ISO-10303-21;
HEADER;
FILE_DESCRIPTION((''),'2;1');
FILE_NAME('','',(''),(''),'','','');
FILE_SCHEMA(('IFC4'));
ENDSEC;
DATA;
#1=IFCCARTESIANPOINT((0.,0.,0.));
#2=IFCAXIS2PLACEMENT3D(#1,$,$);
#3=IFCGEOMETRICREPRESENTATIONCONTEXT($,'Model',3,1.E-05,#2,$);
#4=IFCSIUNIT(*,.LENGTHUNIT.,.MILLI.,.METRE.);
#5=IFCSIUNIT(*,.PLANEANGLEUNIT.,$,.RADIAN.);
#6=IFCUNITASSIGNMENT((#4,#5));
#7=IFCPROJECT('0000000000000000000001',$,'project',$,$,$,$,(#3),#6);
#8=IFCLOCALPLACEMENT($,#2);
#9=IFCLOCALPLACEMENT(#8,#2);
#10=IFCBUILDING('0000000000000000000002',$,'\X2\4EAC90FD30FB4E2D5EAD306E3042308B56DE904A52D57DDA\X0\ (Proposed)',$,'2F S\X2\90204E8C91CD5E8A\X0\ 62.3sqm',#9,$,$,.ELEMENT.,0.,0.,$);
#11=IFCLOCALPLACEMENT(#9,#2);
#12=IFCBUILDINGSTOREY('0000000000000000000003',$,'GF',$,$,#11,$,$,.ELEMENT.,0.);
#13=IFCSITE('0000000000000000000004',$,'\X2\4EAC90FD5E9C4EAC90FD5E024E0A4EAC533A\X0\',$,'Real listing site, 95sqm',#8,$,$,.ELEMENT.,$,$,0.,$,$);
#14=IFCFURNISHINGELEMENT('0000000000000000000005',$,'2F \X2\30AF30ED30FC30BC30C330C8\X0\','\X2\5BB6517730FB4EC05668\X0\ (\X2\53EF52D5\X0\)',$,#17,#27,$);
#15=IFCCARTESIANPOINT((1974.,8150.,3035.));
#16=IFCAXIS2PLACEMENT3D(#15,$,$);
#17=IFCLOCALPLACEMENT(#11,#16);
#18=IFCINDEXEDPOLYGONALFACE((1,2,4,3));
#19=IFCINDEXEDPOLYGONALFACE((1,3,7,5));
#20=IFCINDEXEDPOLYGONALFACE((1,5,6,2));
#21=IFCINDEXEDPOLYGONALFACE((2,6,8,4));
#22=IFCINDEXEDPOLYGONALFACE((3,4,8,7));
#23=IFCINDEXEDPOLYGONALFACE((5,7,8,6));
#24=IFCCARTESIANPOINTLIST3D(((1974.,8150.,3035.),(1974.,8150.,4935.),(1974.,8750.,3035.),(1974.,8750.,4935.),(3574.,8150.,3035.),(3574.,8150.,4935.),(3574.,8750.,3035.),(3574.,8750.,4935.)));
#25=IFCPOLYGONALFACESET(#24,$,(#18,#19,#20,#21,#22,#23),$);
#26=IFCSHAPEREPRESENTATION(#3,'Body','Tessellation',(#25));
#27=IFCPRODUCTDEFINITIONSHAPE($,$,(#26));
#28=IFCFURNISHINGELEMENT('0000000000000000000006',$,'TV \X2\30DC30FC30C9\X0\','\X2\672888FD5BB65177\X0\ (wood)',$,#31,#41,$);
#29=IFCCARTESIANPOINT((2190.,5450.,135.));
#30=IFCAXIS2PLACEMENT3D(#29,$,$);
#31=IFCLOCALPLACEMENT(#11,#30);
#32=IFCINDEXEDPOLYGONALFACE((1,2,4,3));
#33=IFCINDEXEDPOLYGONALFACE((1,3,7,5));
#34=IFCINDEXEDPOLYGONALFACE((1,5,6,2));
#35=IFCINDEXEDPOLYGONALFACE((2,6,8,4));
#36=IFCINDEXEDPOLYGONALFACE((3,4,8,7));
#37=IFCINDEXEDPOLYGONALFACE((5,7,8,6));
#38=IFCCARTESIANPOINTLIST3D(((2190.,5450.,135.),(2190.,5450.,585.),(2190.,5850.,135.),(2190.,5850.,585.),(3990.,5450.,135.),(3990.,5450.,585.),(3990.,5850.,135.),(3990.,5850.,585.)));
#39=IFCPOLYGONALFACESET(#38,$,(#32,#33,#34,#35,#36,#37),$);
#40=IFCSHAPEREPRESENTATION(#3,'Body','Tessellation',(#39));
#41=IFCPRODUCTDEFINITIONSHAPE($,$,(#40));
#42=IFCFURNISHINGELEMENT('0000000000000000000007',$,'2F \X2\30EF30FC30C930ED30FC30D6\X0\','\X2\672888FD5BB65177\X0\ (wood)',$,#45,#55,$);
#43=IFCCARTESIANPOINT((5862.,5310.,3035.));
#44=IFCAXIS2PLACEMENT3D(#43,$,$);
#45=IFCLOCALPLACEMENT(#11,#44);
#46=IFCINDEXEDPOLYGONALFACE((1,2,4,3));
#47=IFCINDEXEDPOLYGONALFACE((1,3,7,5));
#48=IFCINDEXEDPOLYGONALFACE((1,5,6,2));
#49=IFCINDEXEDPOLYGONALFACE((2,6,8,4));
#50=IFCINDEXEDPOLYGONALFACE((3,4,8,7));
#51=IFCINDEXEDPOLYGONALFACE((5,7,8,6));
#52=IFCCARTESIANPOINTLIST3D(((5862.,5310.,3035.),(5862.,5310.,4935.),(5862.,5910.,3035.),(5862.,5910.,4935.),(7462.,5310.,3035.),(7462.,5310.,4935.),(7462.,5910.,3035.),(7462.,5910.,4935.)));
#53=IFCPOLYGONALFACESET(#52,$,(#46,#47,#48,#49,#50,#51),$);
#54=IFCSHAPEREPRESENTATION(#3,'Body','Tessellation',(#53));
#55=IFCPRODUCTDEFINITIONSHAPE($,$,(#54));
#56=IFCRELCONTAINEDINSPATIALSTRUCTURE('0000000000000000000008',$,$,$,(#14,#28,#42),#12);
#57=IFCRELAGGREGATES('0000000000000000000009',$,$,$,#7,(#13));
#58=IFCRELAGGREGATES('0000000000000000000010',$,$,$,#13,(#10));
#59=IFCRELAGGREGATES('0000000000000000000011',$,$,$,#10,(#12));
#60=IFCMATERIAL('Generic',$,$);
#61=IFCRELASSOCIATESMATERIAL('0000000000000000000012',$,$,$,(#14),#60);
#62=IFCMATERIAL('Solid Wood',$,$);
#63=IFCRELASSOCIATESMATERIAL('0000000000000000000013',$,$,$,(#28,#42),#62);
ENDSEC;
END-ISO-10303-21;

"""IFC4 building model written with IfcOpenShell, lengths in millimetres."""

from ifc_helpers import new_model, si_unit, frame, frame_2d, origin, place, context, project, spatial, rectangle, extrude, material, element, save


model = new_model("IFC4")

# Units and contexts
model_context = context("Model", 3, precision=1e-05, world=origin())
ifc_project = project(units=[si_unit("LENGTHUNIT", "METRE", prefix="MILLI"), si_unit("PLANEANGLEUNIT", "RADIAN")], contexts=[model_context])

# Site, building, storey
site_placement = place(None, origin())
site = spatial("IfcSite", under=ifc_project, at=site_placement, Name="京都府京都市上京区", ObjectType="Real listing site, 95sqm", CompositionType="ELEMENT", RefElevation=0.0)
building_placement = place(site_placement, origin())
building = spatial("IfcBuilding", under=site, at=building_placement, Name="京都・中庭のある回遊動線 (Proposed)", ObjectType="2F S造二重床 62.3sqm", CompositionType="ELEMENT", ElevationOfRefHeight=0.0, ElevationOfTerrain=0.0)
storey_placement = place(building_placement, origin())
storey = spatial("IfcBuildingStorey", under=building, at=storey_placement, Name="GF", CompositionType="ELEMENT", Elevation=0.0)

# Shared definitions
ifc_material_1 = material(Name="Solid Wood")

# Shared definitions
ifc_material_2 = material(Name="Generic")

# Furnishing elements
furnishing_1_placement = place(storey_placement, frame((1974.0, 8150.0, 3035.0)))
element("IfcFurnishingElement", 1, at=furnishing_1_placement, inside=storey, material=ifc_material_2, Name="2F クローゼット", Description="家具・什器 (可動)", context=model_context, shape_type="SweptSolid", body=[
    extrude(rectangle(XDim=1600.0, YDim=600.0, at=frame_2d((800.0, 300.0))), frame((1974.0, 8150.0, 3035.0)), (0.0, 0.0, 1.0), 1900.0),
])
furnishing_2_placement = place(storey_placement, frame((2190.0, 5450.0, 135.0)))
element("IfcFurnishingElement", 2, at=furnishing_2_placement, inside=storey, material=ifc_material_1, Name="TV ボード", Description="木製家具 (wood)", context=model_context, shape_type="SweptSolid", body=[
    extrude(rectangle(XDim=1800.0, YDim=400.0, at=frame_2d((900.0, 200.0))), frame((2190.0, 5450.0, 135.0)), (0.0, 0.0, 1.0), 450.0),
])
furnishing_3_placement = place(storey_placement, frame((5862.0, 5310.0, 3035.0)))
element("IfcFurnishingElement", 3, at=furnishing_3_placement, inside=storey, material=ifc_material_1, Name="2F ワードローブ", Description="木製家具 (wood)", context=model_context, shape_type="SweptSolid", body=[
    extrude(rectangle(XDim=1600.0, YDim=600.0, at=frame_2d((800.0, 300.0))), frame((5862.0, 5310.0, 3035.0)), (0.0, 0.0, 1.0), 1900.0),
])

save(model, "model.ifc")
